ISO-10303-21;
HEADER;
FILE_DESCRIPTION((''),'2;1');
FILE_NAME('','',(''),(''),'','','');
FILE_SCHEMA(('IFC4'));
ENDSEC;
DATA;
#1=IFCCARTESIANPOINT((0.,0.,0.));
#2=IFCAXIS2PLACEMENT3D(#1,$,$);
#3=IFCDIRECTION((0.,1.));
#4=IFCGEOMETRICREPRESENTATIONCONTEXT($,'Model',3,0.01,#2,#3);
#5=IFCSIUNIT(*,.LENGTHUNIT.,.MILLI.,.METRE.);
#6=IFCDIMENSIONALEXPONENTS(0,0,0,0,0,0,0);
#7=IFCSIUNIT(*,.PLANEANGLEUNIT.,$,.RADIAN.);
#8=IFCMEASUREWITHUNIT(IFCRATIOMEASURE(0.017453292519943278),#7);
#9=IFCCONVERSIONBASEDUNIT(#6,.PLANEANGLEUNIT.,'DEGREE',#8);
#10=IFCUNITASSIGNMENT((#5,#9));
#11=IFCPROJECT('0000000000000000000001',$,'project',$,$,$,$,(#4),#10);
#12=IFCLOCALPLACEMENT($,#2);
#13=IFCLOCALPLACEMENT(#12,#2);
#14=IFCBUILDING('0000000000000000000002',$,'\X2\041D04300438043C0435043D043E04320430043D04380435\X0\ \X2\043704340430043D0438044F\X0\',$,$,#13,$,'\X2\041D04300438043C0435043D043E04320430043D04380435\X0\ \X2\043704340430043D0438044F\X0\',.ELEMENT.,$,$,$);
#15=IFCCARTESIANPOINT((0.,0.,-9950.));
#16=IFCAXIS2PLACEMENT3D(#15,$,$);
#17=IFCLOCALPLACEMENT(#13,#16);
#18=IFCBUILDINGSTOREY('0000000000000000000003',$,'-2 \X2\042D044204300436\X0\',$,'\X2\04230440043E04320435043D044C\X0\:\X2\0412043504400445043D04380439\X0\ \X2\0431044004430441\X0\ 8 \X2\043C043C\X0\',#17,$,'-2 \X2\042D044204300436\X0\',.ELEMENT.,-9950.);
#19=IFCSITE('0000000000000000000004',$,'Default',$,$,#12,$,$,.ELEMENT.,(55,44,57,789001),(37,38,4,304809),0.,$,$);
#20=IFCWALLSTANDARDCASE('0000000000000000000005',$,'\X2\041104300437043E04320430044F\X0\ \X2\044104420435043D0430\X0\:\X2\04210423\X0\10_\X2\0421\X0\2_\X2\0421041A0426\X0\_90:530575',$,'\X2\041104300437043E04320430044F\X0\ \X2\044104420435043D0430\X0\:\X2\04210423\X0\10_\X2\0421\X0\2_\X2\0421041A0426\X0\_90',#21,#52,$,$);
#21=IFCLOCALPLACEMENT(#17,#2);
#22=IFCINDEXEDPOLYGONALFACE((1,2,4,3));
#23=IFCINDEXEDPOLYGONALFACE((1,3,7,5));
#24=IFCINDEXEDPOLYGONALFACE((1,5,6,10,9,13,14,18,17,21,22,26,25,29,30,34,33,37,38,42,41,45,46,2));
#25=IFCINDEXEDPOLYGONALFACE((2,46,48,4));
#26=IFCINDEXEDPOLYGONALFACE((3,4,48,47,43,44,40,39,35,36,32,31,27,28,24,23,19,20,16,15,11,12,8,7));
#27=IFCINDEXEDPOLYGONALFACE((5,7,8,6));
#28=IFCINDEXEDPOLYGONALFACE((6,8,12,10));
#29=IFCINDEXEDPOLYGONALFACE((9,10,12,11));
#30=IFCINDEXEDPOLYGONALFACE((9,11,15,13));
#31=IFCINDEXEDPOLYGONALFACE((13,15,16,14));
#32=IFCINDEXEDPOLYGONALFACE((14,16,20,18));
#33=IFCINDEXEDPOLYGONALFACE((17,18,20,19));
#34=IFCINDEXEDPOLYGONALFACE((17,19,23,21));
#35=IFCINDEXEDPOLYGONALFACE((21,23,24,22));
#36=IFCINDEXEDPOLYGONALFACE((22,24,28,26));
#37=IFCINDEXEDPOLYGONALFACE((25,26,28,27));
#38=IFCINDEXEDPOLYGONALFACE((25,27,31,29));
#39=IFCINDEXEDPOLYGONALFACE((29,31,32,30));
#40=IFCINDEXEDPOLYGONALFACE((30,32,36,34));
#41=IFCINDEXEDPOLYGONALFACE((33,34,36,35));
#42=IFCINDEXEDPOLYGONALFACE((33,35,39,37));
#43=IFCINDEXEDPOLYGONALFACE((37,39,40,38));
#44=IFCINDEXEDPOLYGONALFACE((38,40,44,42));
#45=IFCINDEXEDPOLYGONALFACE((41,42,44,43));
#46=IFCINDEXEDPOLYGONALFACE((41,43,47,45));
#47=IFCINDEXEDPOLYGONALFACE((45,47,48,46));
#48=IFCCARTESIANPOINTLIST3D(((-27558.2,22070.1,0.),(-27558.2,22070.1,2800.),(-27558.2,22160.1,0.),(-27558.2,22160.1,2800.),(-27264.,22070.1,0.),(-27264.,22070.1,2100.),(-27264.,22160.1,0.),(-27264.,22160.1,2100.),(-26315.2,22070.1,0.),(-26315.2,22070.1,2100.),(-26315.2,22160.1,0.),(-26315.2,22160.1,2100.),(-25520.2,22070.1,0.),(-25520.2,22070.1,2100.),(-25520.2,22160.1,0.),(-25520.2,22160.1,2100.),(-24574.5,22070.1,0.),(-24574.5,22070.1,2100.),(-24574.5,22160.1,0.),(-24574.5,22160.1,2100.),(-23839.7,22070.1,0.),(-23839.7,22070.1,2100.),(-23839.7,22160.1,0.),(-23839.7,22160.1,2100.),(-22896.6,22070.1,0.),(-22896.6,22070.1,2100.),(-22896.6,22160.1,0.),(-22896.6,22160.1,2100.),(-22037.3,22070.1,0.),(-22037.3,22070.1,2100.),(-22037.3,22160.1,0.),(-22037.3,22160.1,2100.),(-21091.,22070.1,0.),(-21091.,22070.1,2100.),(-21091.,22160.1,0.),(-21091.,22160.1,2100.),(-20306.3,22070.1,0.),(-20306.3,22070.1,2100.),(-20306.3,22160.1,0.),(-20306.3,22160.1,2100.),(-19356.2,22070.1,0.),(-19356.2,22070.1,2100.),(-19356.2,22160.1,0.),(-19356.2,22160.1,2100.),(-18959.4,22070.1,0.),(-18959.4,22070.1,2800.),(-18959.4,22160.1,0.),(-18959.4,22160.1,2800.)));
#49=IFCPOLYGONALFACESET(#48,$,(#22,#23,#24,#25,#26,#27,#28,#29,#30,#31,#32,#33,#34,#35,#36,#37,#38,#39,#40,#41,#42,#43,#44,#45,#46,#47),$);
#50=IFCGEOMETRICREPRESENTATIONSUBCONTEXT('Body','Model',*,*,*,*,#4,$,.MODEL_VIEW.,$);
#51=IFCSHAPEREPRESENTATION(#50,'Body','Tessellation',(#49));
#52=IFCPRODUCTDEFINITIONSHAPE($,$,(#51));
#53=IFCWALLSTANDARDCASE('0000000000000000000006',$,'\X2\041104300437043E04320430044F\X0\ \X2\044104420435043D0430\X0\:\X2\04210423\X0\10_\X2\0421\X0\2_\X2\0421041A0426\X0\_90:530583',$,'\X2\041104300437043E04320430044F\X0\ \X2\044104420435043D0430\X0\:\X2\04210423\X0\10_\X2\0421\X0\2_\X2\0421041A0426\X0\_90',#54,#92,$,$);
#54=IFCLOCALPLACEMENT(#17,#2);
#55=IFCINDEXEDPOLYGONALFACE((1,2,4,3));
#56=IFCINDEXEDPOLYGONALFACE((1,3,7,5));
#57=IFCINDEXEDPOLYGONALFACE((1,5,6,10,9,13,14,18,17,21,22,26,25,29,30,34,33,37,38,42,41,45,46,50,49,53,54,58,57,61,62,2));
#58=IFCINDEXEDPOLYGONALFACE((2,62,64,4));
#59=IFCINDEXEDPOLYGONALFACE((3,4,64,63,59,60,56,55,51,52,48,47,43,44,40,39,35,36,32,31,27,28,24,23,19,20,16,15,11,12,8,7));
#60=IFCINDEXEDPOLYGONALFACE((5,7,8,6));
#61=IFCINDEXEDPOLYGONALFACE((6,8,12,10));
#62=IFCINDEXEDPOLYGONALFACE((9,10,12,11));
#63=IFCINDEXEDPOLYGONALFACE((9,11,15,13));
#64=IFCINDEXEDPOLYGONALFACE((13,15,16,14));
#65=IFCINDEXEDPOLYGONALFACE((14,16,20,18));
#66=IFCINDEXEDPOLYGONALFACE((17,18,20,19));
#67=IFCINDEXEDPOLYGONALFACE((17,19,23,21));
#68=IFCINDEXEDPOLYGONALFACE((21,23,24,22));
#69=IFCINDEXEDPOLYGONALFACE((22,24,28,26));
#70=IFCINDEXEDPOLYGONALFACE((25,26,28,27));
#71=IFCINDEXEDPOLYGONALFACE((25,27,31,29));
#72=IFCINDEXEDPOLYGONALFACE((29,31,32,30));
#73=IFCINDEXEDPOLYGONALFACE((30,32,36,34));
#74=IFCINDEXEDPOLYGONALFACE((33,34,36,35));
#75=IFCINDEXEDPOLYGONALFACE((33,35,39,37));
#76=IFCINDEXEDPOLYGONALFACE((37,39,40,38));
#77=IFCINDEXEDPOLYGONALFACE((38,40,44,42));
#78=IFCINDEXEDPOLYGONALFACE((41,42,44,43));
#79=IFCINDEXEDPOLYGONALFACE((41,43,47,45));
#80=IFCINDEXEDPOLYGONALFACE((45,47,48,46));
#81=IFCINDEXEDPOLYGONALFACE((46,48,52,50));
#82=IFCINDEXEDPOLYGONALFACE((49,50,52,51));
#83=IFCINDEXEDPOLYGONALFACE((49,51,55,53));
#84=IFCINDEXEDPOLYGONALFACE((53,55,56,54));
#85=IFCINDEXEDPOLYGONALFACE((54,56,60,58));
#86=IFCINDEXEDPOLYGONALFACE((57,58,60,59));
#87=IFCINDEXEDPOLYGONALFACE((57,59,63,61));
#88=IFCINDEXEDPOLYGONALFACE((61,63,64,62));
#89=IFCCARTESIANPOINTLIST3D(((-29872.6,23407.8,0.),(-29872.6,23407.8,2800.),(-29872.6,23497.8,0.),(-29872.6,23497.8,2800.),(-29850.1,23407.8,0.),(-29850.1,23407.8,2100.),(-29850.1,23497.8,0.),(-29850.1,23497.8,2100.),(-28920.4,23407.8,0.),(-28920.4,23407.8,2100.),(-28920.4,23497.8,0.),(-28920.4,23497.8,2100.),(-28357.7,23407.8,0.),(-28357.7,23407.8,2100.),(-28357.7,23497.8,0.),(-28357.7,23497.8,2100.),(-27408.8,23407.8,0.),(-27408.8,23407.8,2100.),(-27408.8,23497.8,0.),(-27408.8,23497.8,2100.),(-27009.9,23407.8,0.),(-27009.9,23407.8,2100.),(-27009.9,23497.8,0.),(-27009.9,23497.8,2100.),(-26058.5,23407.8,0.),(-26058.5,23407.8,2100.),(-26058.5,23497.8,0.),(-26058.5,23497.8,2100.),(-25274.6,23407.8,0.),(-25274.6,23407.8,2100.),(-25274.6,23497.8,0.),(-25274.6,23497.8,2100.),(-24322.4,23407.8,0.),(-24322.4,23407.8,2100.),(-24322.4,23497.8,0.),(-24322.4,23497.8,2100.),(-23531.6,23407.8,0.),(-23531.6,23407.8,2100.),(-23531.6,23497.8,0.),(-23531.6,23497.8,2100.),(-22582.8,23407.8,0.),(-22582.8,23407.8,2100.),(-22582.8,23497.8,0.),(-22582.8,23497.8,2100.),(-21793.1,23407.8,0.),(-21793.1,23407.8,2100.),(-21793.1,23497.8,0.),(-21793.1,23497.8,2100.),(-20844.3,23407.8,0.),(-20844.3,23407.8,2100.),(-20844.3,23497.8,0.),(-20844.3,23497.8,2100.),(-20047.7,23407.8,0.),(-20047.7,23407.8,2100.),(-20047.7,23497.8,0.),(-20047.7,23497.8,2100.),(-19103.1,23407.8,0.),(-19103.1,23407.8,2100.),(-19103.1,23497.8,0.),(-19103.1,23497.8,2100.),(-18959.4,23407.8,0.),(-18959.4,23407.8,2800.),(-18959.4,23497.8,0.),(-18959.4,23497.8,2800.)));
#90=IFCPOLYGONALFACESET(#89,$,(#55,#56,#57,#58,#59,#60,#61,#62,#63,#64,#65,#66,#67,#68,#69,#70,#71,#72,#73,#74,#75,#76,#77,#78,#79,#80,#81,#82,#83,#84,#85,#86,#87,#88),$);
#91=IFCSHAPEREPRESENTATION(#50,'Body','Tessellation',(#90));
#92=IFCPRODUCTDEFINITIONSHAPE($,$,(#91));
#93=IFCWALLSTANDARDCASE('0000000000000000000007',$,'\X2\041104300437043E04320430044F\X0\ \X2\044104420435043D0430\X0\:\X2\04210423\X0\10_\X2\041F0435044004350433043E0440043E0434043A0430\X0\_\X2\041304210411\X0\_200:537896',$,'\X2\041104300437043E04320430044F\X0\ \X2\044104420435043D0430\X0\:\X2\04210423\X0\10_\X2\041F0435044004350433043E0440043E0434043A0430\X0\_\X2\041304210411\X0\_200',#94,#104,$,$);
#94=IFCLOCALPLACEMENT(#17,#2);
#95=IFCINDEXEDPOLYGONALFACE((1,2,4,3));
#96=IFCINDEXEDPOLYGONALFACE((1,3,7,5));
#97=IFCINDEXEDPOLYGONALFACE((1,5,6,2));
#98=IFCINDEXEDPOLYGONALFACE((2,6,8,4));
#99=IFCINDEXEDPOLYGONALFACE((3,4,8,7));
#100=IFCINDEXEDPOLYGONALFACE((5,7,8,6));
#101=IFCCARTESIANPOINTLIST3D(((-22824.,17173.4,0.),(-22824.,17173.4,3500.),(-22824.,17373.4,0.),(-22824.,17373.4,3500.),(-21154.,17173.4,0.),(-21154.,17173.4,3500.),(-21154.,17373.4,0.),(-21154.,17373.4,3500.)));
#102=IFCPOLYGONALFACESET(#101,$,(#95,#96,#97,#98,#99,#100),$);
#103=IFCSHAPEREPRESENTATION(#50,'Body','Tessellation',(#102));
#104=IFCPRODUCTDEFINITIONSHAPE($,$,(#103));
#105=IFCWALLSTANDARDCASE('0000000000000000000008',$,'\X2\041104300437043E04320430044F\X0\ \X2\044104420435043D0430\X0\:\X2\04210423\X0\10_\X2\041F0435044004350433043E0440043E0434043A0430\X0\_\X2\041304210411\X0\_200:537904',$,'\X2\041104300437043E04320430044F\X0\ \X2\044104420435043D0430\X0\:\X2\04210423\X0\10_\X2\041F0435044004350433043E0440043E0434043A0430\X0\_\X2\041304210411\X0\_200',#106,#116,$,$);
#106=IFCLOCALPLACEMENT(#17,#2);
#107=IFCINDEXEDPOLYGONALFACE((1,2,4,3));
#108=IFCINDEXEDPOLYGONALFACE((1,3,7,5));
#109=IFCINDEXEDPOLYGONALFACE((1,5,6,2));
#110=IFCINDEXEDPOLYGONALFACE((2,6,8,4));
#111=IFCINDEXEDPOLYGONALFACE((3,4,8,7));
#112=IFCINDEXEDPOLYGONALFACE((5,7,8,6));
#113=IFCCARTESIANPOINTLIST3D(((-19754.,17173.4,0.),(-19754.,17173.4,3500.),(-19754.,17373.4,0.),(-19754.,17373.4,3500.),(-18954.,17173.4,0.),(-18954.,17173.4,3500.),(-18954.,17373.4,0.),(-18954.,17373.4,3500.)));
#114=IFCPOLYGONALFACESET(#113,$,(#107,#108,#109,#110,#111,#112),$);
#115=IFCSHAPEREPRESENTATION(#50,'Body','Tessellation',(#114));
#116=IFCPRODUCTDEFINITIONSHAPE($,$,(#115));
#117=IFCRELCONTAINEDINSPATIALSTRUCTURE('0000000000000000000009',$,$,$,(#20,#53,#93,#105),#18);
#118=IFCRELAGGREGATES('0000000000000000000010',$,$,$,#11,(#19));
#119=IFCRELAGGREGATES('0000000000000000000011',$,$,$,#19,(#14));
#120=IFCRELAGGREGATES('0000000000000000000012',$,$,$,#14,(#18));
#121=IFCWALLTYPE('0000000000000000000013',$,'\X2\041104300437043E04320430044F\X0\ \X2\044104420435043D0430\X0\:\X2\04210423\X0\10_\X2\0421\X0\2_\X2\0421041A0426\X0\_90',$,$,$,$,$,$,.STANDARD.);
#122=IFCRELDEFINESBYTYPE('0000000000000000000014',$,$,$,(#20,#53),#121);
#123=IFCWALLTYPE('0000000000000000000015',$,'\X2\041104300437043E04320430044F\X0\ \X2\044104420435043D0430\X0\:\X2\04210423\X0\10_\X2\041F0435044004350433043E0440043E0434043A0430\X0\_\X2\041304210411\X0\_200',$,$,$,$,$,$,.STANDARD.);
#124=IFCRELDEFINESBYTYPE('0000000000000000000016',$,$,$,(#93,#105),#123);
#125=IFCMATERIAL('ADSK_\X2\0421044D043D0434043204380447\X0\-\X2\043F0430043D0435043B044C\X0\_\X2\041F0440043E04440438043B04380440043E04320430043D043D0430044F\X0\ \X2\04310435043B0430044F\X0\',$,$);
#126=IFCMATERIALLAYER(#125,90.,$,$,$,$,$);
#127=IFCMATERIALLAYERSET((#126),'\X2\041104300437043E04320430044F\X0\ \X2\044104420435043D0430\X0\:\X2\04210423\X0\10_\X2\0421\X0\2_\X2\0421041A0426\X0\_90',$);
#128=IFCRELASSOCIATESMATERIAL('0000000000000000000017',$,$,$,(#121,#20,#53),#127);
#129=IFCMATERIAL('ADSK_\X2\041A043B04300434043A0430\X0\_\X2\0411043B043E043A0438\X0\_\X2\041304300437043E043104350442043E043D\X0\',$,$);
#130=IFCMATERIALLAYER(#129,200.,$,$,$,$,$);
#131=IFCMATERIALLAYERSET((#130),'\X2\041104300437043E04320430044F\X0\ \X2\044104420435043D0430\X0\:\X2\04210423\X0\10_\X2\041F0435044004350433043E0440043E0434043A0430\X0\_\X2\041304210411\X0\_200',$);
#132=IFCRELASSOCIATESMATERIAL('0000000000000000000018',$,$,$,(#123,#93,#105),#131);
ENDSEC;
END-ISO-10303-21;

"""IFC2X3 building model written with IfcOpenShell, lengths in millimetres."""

from ifc_helpers import new_model, entity, si_unit, converted_unit, direction, frame, frame_2d, origin, place, context, subcontext, project, spatial, rectangle, extrude, material, layer, layer_set, layer_usage, type_object, element, save


model = new_model("IFC2X3")

# Units and contexts
model_context = context("Model", 3, precision=0.01, world=origin(), true_north=direction((0.0, 1.0)))
body_context = subcontext(model_context, "Body", "Model", "MODEL_VIEW")
ifc_project = project(units=[si_unit("LENGTHUNIT", "METRE", prefix="MILLI"), converted_unit("PLANEANGLEUNIT", "DEGREE", entity("IfcRatioMeasure", 0.017453292519943278), si_unit("PLANEANGLEUNIT", "RADIAN"), dimensions=[0, 0, 0, 0, 0, 0, 0])], contexts=[model_context])

# Site, building, storey
site_placement = place(None, origin())
site = spatial("IfcSite", under=ifc_project, at=site_placement, Name="Default", CompositionType="ELEMENT", RefLatitude=(55, 44, 57, 789001), RefLongitude=(37, 38, 4, 304809), RefElevation=0.0)
building_placement = place(site_placement, origin())
building = spatial("IfcBuilding", under=site, at=building_placement, Name="Наименование здания", LongName="Наименование здания", CompositionType="ELEMENT")
storey_placement = place(building_placement, frame((0.0, 0.0, -9950.0)))
storey = spatial("IfcBuildingStorey", under=building, at=storey_placement, Name="-2 Этаж", ObjectType="Уровень:Верхний брус 8 мм", LongName="-2 Этаж", CompositionType="ELEMENT", Elevation=-9950.0)

# Shared definitions
ifc_material_1 = material(Name="ADSK_Сэндвич-панель_Профилированная белая")
ifc_layer_1 = layer(ifc_material_1, 90.0)
ifc_layer_set_1 = layer_set([ifc_layer_1], Name="Базовая стена:СУ10_С2_СКЦ_90")
ifc_layer_usage_1 = layer_usage(ifc_layer_set_1, "AXIS2", "NEGATIVE", 45.0)
wall_type_1 = type_object("IfcWallType", Name="Базовая стена:СУ10_С2_СКЦ_90", PredefinedType="STANDARD", material=ifc_layer_set_1)

# Walls, openings
wall_1_placement = place(storey_placement, frame((-18959.4, 22115.1, 0.0), z_axis=(0.0, 0.0, 1.0), x_axis=(-1.0, 0.0, 0.0)))
wall_1 = element("IfcWallStandardCase", 1, at=wall_1_placement, inside=storey, type_object=wall_type_1, material=ifc_layer_usage_1, Name="Базовая стена:СУ10_С2_СКЦ_90:530575", ObjectType="Базовая стена:СУ10_С2_СКЦ_90", context=body_context, shape_type="SweptSolid", body=[
    extrude(rectangle(XDim=8598.7, YDim=90.0, at=frame_2d((4299.4, 0.0), x_axis=(1.0, 0.0))), origin(), (0.0, 0.0, 1.0), 2800.0),
])
opening_1_placement = place(wall_1_placement, origin())
element("IfcOpeningElement", 2, at=opening_1_placement, cuts=wall_1, ObjectType="Opening", context=body_context, shape_type="SweptSolid", body=[
    extrude(rectangle(XDim=2100.0, YDim=950.2, at=frame_2d((0.0, 0.0), x_axis=(1.0, 0.0))), frame((871.8, -45.0, 1050.0), z_axis=(0.0, 1.0, 0.0), x_axis=(0.0, 0.0, -1.0)), (0.0, 0.0, 1.0), 90.0),
])
opening_2_placement = place(wall_1_placement, origin())
element("IfcOpeningElement", 3, at=opening_2_placement, cuts=wall_1, ObjectType="Opening", context=body_context, shape_type="SweptSolid", body=[
    extrude(rectangle(XDim=2100.0, YDim=946.3, at=frame_2d((0.0, 0.0), x_axis=(1.0, 0.0))), frame((2604.7, -45.0, 1050.0), z_axis=(0.0, 1.0, 0.0), x_axis=(0.0, 0.0, -1.0)), (0.0, 0.0, 1.0), 90.0),
])
opening_3_placement = place(wall_1_placement, origin())
element("IfcOpeningElement", 4, at=opening_3_placement, cuts=wall_1, ObjectType="Opening", context=body_context, shape_type="SweptSolid", body=[
    extrude(rectangle(XDim=2100.0, YDim=943.1, at=frame_2d((0.0, 0.0), x_axis=(1.0, 0.0))), frame((4408.7, -45.0, 1050.0), z_axis=(0.0, 1.0, 0.0), x_axis=(0.0, 0.0, -1.0)), (0.0, 0.0, 1.0), 90.0),
])
opening_4_placement = place(wall_1_placement, origin())
element("IfcOpeningElement", 5, at=opening_4_placement, cuts=wall_1, ObjectType="Opening", context=body_context, shape_type="SweptSolid", body=[
    extrude(rectangle(XDim=2100.0, YDim=945.6, at=frame_2d((0.0, 0.0), x_axis=(1.0, 0.0))), frame((6087.9, -45.0, 1050.0), z_axis=(0.0, 1.0, 0.0), x_axis=(0.0, 0.0, -1.0)), (0.0, 0.0, 1.0), 90.0),
])
opening_5_placement = place(wall_1_placement, origin())
element("IfcOpeningElement", 6, at=opening_5_placement, cuts=wall_1, ObjectType="Opening", context=body_context, shape_type="SweptSolid", body=[
    extrude(rectangle(XDim=2100.0, YDim=948.8, at=frame_2d((0.0, 0.0), x_axis=(1.0, 0.0))), frame((7830.2, -45.0, 1050.0), z_axis=(0.0, 1.0, 0.0), x_axis=(0.0, 0.0, -1.0)), (0.0, 0.0, 1.0), 90.0),
])
wall_2_placement = place(storey_placement, frame((-18959.4, 23452.8, 0.0), z_axis=(0.0, 0.0, 1.0), x_axis=(-1.0, 0.0, 0.0)))
wall_2 = element("IfcWallStandardCase", 7, at=wall_2_placement, inside=storey, type_object=wall_type_1, material=ifc_layer_usage_1, Name="Базовая стена:СУ10_С2_СКЦ_90:530583", ObjectType="Базовая стена:СУ10_С2_СКЦ_90", context=body_context, shape_type="SweptSolid", body=[
    extrude(rectangle(XDim=10913.2, YDim=90.0, at=frame_2d((5456.6, 0.0), x_axis=(1.0, 0.0))), origin(), (0.0, 0.0, 1.0), 2800.0),
])
opening_6_placement = place(wall_2_placement, origin())
element("IfcOpeningElement", 8, at=opening_6_placement, cuts=wall_2, ObjectType="Opening", context=body_context, shape_type="SweptSolid", body=[
    extrude(rectangle(XDim=2100.0, YDim=929.7, at=frame_2d((0.0, 0.0), x_axis=(1.0, 0.0))), frame((10425.8, -45.0, 1050.0), z_axis=(0.0, 1.0, 0.0), x_axis=(0.0, 0.0, -1.0)), (0.0, 0.0, 1.0), 90.0),
])
opening_7_placement = place(wall_2_placement, origin())
element("IfcOpeningElement", 9, at=opening_7_placement, cuts=wall_2, ObjectType="Opening", context=body_context, shape_type="SweptSolid", body=[
    extrude(rectangle(XDim=2100.0, YDim=948.9, at=frame_2d((0.0, 0.0), x_axis=(1.0, 0.0))), frame((8923.8, -45.0, 1050.0), z_axis=(0.0, 1.0, 0.0), x_axis=(0.0, 0.0, -1.0)), (0.0, 0.0, 1.0), 90.0),
])
opening_8_placement = place(wall_2_placement, origin())
element("IfcOpeningElement", 10, at=opening_8_placement, cuts=wall_2, ObjectType="Opening", context=body_context, shape_type="SweptSolid", body=[
    extrude(rectangle(XDim=2100.0, YDim=951.4, at=frame_2d((0.0, 0.0), x_axis=(1.0, 0.0))), frame((7574.8, -45.0, 1050.0), z_axis=(0.0, 1.0, 0.0), x_axis=(0.0, 0.0, -1.0)), (0.0, 0.0, 1.0), 90.0),
])
opening_9_placement = place(wall_2_placement, origin())
element("IfcOpeningElement", 11, at=opening_9_placement, cuts=wall_2, ObjectType="Opening", context=body_context, shape_type="SweptSolid", body=[
    extrude(rectangle(XDim=2100.0, YDim=952.2, at=frame_2d((0.0, 0.0), x_axis=(1.0, 0.0))), frame((5839.0, -45.0, 1050.0), z_axis=(0.0, 1.0, 0.0), x_axis=(0.0, 0.0, -1.0)), (0.0, 0.0, 1.0), 90.0),
])
opening_10_placement = place(wall_2_placement, origin())
element("IfcOpeningElement", 12, at=opening_10_placement, cuts=wall_2, ObjectType="Opening", context=body_context, shape_type="SweptSolid", body=[
    extrude(rectangle(XDim=2100.0, YDim=948.8, at=frame_2d((0.0, 0.0), x_axis=(1.0, 0.0))), frame((4097.7, -45.0, 1050.0), z_axis=(0.0, 1.0, 0.0), x_axis=(0.0, 0.0, -1.0)), (0.0, 0.0, 1.0), 90.0),
])
opening_11_placement = place(wall_2_placement, origin())
element("IfcOpeningElement", 13, at=opening_11_placement, cuts=wall_2, ObjectType="Opening", context=body_context, shape_type="SweptSolid", body=[
    extrude(rectangle(XDim=2100.0, YDim=948.8, at=frame_2d((0.0, 0.0), x_axis=(1.0, 0.0))), frame((2359.3, -45.0, 1050.0), z_axis=(0.0, 1.0, 0.0), x_axis=(0.0, 0.0, -1.0)), (0.0, 0.0, 1.0), 90.0),
])
opening_12_placement = place(wall_2_placement, origin())
element("IfcOpeningElement", 14, at=opening_12_placement, cuts=wall_2, ObjectType="Opening", context=body_context, shape_type="SweptSolid", body=[
    extrude(rectangle(XDim=2100.0, YDim=944.6, at=frame_2d((0.0, 0.0), x_axis=(1.0, 0.0))), frame((616.0, -45.0, 1050.0), z_axis=(0.0, 1.0, 0.0), x_axis=(0.0, 0.0, -1.0)), (0.0, 0.0, 1.0), 90.0),
])

# Walls
ifc_material_2 = material(Name="ADSK_Кладка_Блоки_Газобетон")
ifc_layer_2 = layer(ifc_material_2, 200.0)
ifc_layer_set_2 = layer_set([ifc_layer_2], Name="Базовая стена:СУ10_Перегородка_ГСБ_200")
ifc_layer_usage_2 = layer_usage(ifc_layer_set_2, "AXIS2", "NEGATIVE", 100.0)
wall_type_2 = type_object("IfcWallType", Name="Базовая стена:СУ10_Перегородка_ГСБ_200", PredefinedType="STANDARD", material=ifc_layer_set_2)
wall_3_placement = place(storey_placement, frame((-21154.0, 17273.4, 0.0), z_axis=(0.0, 0.0, 1.0), x_axis=(-1.0, 0.0, 0.0)))
element("IfcWallStandardCase", 15, at=wall_3_placement, inside=storey, type_object=wall_type_2, material=ifc_layer_usage_2, Name="Базовая стена:СУ10_Перегородка_ГСБ_200:537896", ObjectType="Базовая стена:СУ10_Перегородка_ГСБ_200", context=body_context, shape_type="SweptSolid", body=[
    extrude(rectangle(XDim=1670.1, YDim=200.0, at=frame_2d((835.0, 0.0), x_axis=(-1.0, 0.0))), origin(), (0.0, 0.0, 1.0), 3500.0),
])
wall_4_placement = place(storey_placement, frame((-18954.0, 17273.4, 0.0), z_axis=(0.0, 0.0, 1.0), x_axis=(-1.0, 0.0, 0.0)))
element("IfcWallStandardCase", 16, at=wall_4_placement, inside=storey, type_object=wall_type_2, material=ifc_layer_usage_2, Name="Базовая стена:СУ10_Перегородка_ГСБ_200:537904", ObjectType="Базовая стена:СУ10_Перегородка_ГСБ_200", context=body_context, shape_type="SweptSolid", body=[
    extrude(rectangle(XDim=800.1, YDim=200.0, at=frame_2d((400.0, 0.0), x_axis=(-1.0, 0.0))), origin(), (0.0, 0.0, 1.0), 3500.0),
])

save(model, "model.ifc")
